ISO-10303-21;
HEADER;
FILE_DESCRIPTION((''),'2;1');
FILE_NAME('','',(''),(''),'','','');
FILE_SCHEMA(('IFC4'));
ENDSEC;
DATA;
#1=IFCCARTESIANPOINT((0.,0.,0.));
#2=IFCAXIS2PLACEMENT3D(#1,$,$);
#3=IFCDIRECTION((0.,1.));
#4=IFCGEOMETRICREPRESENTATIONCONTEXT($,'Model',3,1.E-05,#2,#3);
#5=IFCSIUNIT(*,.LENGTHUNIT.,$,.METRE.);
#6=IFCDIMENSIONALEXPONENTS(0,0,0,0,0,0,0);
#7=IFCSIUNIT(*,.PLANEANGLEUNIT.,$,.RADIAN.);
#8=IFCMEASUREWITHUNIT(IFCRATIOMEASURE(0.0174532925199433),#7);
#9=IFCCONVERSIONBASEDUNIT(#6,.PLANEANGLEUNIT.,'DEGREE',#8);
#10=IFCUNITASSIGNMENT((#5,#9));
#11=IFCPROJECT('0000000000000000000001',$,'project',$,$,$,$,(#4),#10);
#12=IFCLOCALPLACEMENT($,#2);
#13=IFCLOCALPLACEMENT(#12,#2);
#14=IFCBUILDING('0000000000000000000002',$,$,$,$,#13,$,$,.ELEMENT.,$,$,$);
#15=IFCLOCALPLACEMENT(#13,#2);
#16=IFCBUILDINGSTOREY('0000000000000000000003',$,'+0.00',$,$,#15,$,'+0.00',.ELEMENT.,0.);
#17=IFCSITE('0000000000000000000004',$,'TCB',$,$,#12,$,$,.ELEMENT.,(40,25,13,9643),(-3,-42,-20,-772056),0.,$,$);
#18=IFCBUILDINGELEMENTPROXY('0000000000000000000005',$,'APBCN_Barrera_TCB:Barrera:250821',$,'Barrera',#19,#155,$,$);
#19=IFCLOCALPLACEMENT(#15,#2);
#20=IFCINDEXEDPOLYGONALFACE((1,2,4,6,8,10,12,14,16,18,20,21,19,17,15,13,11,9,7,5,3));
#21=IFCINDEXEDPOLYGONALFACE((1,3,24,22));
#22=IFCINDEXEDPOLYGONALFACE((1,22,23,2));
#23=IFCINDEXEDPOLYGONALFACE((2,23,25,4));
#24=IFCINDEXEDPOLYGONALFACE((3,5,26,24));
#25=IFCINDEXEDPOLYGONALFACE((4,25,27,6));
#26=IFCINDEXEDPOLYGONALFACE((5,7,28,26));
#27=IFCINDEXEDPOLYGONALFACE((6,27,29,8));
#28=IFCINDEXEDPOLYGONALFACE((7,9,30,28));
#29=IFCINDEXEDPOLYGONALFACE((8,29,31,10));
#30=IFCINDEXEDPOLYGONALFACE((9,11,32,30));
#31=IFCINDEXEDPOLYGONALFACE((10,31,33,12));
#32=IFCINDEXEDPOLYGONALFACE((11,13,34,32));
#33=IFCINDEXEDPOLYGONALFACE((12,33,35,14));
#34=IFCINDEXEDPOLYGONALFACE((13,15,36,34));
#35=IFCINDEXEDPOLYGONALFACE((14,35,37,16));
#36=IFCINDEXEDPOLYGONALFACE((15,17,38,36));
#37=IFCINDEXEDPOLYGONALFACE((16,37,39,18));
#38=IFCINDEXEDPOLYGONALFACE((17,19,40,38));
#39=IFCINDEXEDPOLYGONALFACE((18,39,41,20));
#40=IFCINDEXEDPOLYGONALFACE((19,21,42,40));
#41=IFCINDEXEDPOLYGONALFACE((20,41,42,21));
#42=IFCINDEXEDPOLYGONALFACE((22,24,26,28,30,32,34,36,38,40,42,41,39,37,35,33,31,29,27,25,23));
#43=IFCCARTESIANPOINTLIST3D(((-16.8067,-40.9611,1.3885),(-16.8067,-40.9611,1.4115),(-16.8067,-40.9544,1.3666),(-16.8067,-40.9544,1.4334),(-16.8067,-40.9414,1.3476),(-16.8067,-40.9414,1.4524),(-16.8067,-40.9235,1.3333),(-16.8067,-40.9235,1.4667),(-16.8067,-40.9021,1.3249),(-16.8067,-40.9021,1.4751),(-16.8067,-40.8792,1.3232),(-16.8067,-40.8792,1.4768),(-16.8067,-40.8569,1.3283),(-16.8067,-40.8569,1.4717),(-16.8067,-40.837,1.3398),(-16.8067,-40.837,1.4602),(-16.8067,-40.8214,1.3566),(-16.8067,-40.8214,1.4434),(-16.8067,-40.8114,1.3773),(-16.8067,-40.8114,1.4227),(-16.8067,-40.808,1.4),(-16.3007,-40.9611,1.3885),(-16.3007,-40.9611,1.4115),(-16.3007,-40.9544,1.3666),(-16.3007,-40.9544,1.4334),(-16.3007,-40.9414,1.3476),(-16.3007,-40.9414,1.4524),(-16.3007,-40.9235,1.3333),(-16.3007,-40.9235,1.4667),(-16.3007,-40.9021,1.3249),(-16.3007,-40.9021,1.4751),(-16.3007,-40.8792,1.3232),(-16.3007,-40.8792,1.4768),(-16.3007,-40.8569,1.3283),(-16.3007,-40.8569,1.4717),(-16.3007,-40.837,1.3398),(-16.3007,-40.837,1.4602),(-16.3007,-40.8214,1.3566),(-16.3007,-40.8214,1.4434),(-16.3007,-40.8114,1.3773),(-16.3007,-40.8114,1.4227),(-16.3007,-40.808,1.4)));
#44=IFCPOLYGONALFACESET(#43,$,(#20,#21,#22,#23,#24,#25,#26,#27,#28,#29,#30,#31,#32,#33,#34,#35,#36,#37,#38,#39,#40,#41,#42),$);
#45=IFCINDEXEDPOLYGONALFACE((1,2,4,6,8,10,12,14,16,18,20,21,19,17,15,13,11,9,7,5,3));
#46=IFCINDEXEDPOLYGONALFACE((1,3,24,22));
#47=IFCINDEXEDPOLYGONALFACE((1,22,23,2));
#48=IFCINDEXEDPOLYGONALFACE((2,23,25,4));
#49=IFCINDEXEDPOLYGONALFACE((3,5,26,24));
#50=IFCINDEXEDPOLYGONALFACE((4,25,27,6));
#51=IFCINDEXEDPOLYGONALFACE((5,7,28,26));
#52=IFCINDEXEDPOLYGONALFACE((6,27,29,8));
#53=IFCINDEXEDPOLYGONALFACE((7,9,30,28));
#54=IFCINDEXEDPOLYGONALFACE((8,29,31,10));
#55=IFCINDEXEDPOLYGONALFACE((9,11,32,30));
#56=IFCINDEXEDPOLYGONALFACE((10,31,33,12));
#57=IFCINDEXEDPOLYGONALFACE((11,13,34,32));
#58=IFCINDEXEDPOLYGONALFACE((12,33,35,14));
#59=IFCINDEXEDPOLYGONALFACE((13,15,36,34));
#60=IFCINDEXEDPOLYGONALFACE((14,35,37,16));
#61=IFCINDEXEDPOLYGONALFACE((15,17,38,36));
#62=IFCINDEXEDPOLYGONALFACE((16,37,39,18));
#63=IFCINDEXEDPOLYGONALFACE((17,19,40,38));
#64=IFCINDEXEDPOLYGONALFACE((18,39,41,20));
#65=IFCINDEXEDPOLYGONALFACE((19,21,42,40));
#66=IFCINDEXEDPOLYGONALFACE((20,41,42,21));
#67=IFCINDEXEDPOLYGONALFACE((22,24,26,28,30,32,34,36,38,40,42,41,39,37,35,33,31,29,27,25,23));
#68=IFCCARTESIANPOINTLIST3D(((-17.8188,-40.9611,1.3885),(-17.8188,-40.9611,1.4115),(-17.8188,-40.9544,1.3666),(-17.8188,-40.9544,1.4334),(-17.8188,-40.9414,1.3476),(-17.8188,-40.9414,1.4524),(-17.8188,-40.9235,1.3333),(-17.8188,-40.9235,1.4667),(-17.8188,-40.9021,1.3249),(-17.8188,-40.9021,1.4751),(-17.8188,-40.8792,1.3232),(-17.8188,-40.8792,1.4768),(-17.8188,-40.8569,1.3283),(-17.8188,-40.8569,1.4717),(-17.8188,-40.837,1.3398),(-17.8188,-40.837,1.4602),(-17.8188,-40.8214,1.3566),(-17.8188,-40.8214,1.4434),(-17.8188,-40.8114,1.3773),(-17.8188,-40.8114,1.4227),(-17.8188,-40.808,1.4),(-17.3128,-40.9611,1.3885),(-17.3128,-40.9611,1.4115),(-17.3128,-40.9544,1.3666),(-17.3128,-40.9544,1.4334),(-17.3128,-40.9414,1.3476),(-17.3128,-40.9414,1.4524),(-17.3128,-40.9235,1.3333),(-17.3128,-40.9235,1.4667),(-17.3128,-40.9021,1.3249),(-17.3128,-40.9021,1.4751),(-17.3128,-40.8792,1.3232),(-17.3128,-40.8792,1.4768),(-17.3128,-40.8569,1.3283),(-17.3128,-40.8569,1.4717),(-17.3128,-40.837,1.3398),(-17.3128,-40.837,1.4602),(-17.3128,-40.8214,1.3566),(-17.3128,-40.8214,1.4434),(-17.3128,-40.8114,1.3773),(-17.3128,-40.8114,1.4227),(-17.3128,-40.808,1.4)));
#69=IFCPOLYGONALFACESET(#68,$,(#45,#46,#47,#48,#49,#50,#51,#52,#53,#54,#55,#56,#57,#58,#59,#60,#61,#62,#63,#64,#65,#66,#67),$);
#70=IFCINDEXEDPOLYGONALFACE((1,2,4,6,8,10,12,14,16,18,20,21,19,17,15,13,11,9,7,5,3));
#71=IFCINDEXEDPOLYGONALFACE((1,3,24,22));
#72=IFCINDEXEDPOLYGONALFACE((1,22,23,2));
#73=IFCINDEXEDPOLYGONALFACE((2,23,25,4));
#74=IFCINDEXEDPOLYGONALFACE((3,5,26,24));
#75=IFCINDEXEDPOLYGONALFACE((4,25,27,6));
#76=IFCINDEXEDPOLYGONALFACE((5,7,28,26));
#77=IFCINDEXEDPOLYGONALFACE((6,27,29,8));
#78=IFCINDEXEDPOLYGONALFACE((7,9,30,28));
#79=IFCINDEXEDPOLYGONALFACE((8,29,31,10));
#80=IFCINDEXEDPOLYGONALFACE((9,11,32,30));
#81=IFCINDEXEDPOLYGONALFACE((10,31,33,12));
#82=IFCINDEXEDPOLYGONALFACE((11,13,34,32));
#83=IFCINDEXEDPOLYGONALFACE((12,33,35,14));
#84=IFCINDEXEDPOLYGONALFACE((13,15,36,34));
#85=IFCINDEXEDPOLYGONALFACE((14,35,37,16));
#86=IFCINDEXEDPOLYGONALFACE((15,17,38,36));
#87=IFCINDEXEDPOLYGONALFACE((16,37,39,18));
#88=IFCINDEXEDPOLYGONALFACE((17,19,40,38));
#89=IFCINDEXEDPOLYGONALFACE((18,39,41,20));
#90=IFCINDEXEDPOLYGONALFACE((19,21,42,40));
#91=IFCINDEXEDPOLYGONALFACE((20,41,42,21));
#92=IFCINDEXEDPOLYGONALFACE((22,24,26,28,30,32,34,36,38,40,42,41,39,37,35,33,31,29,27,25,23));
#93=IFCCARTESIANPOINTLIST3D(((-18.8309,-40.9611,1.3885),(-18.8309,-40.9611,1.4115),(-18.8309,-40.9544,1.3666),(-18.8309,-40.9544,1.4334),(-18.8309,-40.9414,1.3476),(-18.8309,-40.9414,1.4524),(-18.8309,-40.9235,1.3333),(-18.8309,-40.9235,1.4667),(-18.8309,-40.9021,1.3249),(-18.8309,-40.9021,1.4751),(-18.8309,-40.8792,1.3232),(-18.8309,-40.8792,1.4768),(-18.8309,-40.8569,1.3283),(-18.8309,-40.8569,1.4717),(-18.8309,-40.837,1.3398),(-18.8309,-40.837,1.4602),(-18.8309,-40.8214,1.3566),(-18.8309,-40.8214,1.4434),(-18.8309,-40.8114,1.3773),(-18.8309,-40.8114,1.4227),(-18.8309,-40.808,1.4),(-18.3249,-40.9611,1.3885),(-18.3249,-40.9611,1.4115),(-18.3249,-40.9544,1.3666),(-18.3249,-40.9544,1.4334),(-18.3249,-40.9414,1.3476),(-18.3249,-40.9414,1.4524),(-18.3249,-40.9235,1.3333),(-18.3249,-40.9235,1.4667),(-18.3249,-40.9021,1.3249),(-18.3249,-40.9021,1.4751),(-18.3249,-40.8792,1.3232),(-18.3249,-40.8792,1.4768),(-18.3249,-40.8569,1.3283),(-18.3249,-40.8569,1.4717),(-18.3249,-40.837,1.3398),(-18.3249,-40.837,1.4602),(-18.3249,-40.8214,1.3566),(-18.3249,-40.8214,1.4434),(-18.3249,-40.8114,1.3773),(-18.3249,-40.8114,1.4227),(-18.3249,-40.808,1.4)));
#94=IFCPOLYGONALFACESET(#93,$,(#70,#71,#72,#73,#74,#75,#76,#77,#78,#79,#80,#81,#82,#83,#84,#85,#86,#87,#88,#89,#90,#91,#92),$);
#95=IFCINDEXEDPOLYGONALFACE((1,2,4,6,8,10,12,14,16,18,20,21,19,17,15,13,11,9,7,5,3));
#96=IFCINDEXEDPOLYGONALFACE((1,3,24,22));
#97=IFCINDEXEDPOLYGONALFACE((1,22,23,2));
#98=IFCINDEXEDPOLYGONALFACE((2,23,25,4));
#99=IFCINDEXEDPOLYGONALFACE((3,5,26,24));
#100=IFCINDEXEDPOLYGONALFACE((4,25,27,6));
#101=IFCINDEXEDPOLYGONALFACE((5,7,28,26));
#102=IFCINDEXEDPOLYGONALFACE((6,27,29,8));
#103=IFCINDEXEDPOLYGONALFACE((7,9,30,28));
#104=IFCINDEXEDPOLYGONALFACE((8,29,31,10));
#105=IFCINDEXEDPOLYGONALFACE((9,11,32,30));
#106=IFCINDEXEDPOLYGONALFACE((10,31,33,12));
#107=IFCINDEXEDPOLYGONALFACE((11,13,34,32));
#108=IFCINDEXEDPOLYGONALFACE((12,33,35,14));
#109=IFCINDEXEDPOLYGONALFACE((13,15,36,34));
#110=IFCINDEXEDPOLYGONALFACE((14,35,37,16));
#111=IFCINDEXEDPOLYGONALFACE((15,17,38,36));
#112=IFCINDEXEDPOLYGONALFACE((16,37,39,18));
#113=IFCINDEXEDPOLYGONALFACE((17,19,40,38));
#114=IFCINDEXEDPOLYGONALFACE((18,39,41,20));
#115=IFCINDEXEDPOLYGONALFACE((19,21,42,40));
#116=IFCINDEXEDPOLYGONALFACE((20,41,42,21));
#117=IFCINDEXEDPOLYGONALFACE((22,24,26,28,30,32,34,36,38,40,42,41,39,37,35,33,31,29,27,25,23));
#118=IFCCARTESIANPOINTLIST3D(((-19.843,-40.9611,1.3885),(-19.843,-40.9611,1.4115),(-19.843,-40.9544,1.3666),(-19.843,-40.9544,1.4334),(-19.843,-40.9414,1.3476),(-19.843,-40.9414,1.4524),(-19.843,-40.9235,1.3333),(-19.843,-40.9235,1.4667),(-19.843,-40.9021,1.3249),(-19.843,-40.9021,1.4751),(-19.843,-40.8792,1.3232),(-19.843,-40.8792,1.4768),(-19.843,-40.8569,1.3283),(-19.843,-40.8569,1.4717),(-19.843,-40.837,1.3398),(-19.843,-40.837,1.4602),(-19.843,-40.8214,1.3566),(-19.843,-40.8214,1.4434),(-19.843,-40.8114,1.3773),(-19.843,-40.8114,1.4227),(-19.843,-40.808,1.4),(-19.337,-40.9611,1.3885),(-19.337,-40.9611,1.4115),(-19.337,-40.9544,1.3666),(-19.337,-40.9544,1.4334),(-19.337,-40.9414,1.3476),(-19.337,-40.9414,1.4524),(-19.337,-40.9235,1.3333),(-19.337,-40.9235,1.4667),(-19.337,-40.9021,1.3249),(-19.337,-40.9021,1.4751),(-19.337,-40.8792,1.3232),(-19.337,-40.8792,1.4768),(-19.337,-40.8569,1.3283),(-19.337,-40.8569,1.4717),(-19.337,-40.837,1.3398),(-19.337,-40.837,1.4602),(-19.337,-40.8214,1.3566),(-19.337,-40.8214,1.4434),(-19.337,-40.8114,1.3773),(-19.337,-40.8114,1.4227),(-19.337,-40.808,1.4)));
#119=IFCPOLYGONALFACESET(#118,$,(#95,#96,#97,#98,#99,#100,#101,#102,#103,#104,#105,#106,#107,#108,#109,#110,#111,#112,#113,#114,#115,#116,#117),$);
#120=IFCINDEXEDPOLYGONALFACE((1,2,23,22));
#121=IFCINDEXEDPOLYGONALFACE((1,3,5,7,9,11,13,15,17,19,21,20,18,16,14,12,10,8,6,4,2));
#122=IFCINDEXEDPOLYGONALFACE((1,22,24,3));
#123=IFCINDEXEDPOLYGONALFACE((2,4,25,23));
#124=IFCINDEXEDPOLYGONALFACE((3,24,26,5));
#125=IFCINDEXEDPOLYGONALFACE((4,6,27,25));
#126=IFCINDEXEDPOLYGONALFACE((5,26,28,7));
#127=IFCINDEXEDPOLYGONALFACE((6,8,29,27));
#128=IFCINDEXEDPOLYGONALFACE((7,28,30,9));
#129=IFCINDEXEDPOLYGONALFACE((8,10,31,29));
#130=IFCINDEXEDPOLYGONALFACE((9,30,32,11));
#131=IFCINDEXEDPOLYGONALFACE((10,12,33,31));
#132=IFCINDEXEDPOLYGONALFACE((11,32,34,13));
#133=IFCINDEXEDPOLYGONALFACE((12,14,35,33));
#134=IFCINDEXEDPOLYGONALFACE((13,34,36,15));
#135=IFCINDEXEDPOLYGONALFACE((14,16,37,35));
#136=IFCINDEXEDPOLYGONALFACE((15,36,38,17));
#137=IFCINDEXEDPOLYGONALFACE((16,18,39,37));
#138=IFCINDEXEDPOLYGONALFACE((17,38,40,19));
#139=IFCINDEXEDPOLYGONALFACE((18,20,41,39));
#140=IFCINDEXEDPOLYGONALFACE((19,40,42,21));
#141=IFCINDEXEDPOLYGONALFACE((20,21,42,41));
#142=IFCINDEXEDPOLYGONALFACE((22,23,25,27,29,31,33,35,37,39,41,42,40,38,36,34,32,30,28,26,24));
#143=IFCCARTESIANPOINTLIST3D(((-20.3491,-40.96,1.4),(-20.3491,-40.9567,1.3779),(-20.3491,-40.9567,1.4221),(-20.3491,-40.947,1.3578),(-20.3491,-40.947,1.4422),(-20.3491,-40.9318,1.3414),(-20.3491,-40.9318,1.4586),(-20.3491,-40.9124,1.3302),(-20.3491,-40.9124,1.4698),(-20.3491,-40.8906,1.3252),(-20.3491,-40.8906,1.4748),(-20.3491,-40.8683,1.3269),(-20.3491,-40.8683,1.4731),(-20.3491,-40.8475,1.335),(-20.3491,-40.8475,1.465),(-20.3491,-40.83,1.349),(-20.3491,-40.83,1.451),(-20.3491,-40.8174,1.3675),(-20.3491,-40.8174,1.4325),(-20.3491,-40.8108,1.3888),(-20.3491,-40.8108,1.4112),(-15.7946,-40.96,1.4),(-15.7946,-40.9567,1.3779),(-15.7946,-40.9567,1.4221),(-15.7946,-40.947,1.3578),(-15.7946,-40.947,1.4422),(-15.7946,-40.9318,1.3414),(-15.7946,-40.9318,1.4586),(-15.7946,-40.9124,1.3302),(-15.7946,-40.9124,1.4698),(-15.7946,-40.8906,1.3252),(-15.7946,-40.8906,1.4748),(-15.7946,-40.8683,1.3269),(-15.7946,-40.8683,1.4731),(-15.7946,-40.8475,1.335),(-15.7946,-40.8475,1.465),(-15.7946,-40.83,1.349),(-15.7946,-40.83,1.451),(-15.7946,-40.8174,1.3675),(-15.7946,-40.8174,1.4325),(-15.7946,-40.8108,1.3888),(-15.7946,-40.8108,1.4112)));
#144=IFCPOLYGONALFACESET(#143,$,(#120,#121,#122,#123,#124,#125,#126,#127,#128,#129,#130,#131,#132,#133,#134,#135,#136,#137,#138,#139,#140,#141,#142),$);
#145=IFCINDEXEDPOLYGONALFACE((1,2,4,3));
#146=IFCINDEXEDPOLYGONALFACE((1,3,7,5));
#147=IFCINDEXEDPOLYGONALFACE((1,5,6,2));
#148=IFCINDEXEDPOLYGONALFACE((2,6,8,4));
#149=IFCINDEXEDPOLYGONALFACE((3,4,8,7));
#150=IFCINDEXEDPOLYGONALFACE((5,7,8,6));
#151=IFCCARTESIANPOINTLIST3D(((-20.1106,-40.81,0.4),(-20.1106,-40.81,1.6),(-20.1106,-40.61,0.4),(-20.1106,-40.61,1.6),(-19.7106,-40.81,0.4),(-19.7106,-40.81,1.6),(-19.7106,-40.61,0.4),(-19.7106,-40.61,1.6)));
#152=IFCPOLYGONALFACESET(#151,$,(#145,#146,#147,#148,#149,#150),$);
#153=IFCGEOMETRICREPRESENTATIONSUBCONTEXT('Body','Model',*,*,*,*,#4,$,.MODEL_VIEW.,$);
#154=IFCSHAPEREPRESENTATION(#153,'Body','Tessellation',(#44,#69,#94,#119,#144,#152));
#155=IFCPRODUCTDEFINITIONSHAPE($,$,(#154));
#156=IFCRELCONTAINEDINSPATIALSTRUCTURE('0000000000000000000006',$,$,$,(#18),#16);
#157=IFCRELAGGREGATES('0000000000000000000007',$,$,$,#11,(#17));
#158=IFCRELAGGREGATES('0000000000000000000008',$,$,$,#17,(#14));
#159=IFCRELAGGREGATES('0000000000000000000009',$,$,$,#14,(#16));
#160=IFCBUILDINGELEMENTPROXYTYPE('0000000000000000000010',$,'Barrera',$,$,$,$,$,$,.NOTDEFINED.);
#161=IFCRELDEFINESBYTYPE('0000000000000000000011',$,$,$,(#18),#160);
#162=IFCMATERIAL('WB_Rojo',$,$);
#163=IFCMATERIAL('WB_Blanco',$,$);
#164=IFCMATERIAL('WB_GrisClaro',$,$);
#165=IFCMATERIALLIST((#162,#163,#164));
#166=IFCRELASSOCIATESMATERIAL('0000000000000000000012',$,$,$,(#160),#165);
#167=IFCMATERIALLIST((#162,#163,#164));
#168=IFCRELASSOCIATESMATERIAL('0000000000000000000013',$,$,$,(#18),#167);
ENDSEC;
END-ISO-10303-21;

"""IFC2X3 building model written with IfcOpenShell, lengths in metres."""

from ifc_helpers import new_model, entity, si_unit, converted_unit, direction, frame, frame_2d, origin, place, context, subcontext, project, spatial, rectangle, circle, extrude, source, transform, mapped, material, material_list, type_object, type_shapes, element, save


model = new_model("IFC2X3")

# Units and contexts
model_context = context("Model", 3, precision=1e-05, world=origin(), true_north=direction((0.0, 1.0)))
body_context = subcontext(model_context, "Body", "Model", "MODEL_VIEW")
ifc_project = project(units=[si_unit("LENGTHUNIT", "METRE"), converted_unit("PLANEANGLEUNIT", "DEGREE", entity("IfcRatioMeasure", 0.0174532925199433), si_unit("PLANEANGLEUNIT", "RADIAN"), dimensions=[0, 0, 0, 0, 0, 0, 0])], contexts=[model_context])

# Site, building, storey
site_placement = place(None, origin())
site = spatial("IfcSite", under=ifc_project, at=site_placement, Name="TCB", CompositionType="ELEMENT", RefLatitude=(40, 25, 13, 9643), RefLongitude=(-3, -42, -20, -772056), RefElevation=0.0)
building_placement = place(site_placement, origin())
building = spatial("IfcBuilding", under=site, at=building_placement, CompositionType="ELEMENT")
storey_placement = place(building_placement, origin())
storey = spatial("IfcBuildingStorey", under=building, at=storey_placement, Name="+0.00", LongName="+0.00", CompositionType="ELEMENT", Elevation=0.0)

# Shared definitions
ifc_material_1 = material(Name="WB_GrisClaro")

# Building element proxy
ifc_material_2 = material(Name="WB_Rojo")
ifc_material_3 = material(Name="WB_Blanco")
ifc_material_list_1 = material_list([ifc_material_2, ifc_material_3, ifc_material_1])
building_element_proxy_type_1 = type_object("IfcBuildingElementProxyType", Name="Barrera", PredefinedType="NOTDEFINED", material=ifc_material_list_1)
shared_shape_1 = source(origin(), body_context, "Body", "SweptSolid", [
    extrude(circle(Radius=0.077, at=frame_2d((0.0, 0.0), x_axis=(1.0, 0.0))), frame((2.8039, -0.175, 1.0), z_axis=(1.0, 0.0, 0.0), x_axis=(0.0, 1.0, 0.0)), (0.0, 0.0, 1.0), 0.506),
    extrude(circle(Radius=0.077, at=frame_2d((0.0, 0.0), x_axis=(1.0, 0.0))), frame((1.7918, -0.175, 1.0), z_axis=(1.0, 0.0, 0.0), x_axis=(0.0, 1.0, 0.0)), (0.0, 0.0, 1.0), 0.506),
    extrude(circle(Radius=0.077, at=frame_2d((0.0, 0.0), x_axis=(1.0, 0.0))), frame((0.7797, -0.175, 1.0), z_axis=(1.0, 0.0, 0.0), x_axis=(0.0, 1.0, 0.0)), (0.0, 0.0, 1.0), 0.506),
    extrude(circle(Radius=0.077, at=frame_2d((0.0, 0.0), x_axis=(1.0, 0.0))), frame((-0.2324, -0.175, 1.0), z_axis=(1.0, 0.0, 0.0), x_axis=(0.0, 1.0, 0.0)), (0.0, 0.0, 1.0), 0.506),
    extrude(circle(Radius=0.075, at=frame_2d((0.0, 0.0), x_axis=(1.0, 0.0))), frame((-0.7385, -0.175, 1.0), z_axis=(1.0, 0.0, 0.0), x_axis=(0.0, -1.0, 0.0)), (0.0, 0.0, 1.0), 4.5544),
    extrude(rectangle(XDim=0.2, YDim=0.4, at=frame_2d((0.0, 0.0), x_axis=(1.0, 0.0))), frame((-0.3, 0.0, 0.0), z_axis=(0.0, 0.0, 1.0), x_axis=(0.0, -1.0, 0.0)), (0.0, 0.0, 1.0), 1.2),
])
type_shapes(building_element_proxy_type_1, [shared_shape_1])
ifc_material_list_2 = material_list([ifc_material_2, ifc_material_3, ifc_material_1])
proxy_1_placement = place(storey_placement, frame((-19.6106, -40.71, 0.4)))
element("IfcBuildingElementProxy", 1, at=proxy_1_placement, inside=storey, type_object=building_element_proxy_type_1, material=ifc_material_list_2, Name="APBCN_Barrera_TCB:Barrera:250821", ObjectType="Barrera", context=body_context, shape_type="MappedRepresentation", body=[
    mapped(shared_shape_1, transform((0.0, 0.0, 0.0), scale=1.0)),
])

save(model, "model.ifc")
